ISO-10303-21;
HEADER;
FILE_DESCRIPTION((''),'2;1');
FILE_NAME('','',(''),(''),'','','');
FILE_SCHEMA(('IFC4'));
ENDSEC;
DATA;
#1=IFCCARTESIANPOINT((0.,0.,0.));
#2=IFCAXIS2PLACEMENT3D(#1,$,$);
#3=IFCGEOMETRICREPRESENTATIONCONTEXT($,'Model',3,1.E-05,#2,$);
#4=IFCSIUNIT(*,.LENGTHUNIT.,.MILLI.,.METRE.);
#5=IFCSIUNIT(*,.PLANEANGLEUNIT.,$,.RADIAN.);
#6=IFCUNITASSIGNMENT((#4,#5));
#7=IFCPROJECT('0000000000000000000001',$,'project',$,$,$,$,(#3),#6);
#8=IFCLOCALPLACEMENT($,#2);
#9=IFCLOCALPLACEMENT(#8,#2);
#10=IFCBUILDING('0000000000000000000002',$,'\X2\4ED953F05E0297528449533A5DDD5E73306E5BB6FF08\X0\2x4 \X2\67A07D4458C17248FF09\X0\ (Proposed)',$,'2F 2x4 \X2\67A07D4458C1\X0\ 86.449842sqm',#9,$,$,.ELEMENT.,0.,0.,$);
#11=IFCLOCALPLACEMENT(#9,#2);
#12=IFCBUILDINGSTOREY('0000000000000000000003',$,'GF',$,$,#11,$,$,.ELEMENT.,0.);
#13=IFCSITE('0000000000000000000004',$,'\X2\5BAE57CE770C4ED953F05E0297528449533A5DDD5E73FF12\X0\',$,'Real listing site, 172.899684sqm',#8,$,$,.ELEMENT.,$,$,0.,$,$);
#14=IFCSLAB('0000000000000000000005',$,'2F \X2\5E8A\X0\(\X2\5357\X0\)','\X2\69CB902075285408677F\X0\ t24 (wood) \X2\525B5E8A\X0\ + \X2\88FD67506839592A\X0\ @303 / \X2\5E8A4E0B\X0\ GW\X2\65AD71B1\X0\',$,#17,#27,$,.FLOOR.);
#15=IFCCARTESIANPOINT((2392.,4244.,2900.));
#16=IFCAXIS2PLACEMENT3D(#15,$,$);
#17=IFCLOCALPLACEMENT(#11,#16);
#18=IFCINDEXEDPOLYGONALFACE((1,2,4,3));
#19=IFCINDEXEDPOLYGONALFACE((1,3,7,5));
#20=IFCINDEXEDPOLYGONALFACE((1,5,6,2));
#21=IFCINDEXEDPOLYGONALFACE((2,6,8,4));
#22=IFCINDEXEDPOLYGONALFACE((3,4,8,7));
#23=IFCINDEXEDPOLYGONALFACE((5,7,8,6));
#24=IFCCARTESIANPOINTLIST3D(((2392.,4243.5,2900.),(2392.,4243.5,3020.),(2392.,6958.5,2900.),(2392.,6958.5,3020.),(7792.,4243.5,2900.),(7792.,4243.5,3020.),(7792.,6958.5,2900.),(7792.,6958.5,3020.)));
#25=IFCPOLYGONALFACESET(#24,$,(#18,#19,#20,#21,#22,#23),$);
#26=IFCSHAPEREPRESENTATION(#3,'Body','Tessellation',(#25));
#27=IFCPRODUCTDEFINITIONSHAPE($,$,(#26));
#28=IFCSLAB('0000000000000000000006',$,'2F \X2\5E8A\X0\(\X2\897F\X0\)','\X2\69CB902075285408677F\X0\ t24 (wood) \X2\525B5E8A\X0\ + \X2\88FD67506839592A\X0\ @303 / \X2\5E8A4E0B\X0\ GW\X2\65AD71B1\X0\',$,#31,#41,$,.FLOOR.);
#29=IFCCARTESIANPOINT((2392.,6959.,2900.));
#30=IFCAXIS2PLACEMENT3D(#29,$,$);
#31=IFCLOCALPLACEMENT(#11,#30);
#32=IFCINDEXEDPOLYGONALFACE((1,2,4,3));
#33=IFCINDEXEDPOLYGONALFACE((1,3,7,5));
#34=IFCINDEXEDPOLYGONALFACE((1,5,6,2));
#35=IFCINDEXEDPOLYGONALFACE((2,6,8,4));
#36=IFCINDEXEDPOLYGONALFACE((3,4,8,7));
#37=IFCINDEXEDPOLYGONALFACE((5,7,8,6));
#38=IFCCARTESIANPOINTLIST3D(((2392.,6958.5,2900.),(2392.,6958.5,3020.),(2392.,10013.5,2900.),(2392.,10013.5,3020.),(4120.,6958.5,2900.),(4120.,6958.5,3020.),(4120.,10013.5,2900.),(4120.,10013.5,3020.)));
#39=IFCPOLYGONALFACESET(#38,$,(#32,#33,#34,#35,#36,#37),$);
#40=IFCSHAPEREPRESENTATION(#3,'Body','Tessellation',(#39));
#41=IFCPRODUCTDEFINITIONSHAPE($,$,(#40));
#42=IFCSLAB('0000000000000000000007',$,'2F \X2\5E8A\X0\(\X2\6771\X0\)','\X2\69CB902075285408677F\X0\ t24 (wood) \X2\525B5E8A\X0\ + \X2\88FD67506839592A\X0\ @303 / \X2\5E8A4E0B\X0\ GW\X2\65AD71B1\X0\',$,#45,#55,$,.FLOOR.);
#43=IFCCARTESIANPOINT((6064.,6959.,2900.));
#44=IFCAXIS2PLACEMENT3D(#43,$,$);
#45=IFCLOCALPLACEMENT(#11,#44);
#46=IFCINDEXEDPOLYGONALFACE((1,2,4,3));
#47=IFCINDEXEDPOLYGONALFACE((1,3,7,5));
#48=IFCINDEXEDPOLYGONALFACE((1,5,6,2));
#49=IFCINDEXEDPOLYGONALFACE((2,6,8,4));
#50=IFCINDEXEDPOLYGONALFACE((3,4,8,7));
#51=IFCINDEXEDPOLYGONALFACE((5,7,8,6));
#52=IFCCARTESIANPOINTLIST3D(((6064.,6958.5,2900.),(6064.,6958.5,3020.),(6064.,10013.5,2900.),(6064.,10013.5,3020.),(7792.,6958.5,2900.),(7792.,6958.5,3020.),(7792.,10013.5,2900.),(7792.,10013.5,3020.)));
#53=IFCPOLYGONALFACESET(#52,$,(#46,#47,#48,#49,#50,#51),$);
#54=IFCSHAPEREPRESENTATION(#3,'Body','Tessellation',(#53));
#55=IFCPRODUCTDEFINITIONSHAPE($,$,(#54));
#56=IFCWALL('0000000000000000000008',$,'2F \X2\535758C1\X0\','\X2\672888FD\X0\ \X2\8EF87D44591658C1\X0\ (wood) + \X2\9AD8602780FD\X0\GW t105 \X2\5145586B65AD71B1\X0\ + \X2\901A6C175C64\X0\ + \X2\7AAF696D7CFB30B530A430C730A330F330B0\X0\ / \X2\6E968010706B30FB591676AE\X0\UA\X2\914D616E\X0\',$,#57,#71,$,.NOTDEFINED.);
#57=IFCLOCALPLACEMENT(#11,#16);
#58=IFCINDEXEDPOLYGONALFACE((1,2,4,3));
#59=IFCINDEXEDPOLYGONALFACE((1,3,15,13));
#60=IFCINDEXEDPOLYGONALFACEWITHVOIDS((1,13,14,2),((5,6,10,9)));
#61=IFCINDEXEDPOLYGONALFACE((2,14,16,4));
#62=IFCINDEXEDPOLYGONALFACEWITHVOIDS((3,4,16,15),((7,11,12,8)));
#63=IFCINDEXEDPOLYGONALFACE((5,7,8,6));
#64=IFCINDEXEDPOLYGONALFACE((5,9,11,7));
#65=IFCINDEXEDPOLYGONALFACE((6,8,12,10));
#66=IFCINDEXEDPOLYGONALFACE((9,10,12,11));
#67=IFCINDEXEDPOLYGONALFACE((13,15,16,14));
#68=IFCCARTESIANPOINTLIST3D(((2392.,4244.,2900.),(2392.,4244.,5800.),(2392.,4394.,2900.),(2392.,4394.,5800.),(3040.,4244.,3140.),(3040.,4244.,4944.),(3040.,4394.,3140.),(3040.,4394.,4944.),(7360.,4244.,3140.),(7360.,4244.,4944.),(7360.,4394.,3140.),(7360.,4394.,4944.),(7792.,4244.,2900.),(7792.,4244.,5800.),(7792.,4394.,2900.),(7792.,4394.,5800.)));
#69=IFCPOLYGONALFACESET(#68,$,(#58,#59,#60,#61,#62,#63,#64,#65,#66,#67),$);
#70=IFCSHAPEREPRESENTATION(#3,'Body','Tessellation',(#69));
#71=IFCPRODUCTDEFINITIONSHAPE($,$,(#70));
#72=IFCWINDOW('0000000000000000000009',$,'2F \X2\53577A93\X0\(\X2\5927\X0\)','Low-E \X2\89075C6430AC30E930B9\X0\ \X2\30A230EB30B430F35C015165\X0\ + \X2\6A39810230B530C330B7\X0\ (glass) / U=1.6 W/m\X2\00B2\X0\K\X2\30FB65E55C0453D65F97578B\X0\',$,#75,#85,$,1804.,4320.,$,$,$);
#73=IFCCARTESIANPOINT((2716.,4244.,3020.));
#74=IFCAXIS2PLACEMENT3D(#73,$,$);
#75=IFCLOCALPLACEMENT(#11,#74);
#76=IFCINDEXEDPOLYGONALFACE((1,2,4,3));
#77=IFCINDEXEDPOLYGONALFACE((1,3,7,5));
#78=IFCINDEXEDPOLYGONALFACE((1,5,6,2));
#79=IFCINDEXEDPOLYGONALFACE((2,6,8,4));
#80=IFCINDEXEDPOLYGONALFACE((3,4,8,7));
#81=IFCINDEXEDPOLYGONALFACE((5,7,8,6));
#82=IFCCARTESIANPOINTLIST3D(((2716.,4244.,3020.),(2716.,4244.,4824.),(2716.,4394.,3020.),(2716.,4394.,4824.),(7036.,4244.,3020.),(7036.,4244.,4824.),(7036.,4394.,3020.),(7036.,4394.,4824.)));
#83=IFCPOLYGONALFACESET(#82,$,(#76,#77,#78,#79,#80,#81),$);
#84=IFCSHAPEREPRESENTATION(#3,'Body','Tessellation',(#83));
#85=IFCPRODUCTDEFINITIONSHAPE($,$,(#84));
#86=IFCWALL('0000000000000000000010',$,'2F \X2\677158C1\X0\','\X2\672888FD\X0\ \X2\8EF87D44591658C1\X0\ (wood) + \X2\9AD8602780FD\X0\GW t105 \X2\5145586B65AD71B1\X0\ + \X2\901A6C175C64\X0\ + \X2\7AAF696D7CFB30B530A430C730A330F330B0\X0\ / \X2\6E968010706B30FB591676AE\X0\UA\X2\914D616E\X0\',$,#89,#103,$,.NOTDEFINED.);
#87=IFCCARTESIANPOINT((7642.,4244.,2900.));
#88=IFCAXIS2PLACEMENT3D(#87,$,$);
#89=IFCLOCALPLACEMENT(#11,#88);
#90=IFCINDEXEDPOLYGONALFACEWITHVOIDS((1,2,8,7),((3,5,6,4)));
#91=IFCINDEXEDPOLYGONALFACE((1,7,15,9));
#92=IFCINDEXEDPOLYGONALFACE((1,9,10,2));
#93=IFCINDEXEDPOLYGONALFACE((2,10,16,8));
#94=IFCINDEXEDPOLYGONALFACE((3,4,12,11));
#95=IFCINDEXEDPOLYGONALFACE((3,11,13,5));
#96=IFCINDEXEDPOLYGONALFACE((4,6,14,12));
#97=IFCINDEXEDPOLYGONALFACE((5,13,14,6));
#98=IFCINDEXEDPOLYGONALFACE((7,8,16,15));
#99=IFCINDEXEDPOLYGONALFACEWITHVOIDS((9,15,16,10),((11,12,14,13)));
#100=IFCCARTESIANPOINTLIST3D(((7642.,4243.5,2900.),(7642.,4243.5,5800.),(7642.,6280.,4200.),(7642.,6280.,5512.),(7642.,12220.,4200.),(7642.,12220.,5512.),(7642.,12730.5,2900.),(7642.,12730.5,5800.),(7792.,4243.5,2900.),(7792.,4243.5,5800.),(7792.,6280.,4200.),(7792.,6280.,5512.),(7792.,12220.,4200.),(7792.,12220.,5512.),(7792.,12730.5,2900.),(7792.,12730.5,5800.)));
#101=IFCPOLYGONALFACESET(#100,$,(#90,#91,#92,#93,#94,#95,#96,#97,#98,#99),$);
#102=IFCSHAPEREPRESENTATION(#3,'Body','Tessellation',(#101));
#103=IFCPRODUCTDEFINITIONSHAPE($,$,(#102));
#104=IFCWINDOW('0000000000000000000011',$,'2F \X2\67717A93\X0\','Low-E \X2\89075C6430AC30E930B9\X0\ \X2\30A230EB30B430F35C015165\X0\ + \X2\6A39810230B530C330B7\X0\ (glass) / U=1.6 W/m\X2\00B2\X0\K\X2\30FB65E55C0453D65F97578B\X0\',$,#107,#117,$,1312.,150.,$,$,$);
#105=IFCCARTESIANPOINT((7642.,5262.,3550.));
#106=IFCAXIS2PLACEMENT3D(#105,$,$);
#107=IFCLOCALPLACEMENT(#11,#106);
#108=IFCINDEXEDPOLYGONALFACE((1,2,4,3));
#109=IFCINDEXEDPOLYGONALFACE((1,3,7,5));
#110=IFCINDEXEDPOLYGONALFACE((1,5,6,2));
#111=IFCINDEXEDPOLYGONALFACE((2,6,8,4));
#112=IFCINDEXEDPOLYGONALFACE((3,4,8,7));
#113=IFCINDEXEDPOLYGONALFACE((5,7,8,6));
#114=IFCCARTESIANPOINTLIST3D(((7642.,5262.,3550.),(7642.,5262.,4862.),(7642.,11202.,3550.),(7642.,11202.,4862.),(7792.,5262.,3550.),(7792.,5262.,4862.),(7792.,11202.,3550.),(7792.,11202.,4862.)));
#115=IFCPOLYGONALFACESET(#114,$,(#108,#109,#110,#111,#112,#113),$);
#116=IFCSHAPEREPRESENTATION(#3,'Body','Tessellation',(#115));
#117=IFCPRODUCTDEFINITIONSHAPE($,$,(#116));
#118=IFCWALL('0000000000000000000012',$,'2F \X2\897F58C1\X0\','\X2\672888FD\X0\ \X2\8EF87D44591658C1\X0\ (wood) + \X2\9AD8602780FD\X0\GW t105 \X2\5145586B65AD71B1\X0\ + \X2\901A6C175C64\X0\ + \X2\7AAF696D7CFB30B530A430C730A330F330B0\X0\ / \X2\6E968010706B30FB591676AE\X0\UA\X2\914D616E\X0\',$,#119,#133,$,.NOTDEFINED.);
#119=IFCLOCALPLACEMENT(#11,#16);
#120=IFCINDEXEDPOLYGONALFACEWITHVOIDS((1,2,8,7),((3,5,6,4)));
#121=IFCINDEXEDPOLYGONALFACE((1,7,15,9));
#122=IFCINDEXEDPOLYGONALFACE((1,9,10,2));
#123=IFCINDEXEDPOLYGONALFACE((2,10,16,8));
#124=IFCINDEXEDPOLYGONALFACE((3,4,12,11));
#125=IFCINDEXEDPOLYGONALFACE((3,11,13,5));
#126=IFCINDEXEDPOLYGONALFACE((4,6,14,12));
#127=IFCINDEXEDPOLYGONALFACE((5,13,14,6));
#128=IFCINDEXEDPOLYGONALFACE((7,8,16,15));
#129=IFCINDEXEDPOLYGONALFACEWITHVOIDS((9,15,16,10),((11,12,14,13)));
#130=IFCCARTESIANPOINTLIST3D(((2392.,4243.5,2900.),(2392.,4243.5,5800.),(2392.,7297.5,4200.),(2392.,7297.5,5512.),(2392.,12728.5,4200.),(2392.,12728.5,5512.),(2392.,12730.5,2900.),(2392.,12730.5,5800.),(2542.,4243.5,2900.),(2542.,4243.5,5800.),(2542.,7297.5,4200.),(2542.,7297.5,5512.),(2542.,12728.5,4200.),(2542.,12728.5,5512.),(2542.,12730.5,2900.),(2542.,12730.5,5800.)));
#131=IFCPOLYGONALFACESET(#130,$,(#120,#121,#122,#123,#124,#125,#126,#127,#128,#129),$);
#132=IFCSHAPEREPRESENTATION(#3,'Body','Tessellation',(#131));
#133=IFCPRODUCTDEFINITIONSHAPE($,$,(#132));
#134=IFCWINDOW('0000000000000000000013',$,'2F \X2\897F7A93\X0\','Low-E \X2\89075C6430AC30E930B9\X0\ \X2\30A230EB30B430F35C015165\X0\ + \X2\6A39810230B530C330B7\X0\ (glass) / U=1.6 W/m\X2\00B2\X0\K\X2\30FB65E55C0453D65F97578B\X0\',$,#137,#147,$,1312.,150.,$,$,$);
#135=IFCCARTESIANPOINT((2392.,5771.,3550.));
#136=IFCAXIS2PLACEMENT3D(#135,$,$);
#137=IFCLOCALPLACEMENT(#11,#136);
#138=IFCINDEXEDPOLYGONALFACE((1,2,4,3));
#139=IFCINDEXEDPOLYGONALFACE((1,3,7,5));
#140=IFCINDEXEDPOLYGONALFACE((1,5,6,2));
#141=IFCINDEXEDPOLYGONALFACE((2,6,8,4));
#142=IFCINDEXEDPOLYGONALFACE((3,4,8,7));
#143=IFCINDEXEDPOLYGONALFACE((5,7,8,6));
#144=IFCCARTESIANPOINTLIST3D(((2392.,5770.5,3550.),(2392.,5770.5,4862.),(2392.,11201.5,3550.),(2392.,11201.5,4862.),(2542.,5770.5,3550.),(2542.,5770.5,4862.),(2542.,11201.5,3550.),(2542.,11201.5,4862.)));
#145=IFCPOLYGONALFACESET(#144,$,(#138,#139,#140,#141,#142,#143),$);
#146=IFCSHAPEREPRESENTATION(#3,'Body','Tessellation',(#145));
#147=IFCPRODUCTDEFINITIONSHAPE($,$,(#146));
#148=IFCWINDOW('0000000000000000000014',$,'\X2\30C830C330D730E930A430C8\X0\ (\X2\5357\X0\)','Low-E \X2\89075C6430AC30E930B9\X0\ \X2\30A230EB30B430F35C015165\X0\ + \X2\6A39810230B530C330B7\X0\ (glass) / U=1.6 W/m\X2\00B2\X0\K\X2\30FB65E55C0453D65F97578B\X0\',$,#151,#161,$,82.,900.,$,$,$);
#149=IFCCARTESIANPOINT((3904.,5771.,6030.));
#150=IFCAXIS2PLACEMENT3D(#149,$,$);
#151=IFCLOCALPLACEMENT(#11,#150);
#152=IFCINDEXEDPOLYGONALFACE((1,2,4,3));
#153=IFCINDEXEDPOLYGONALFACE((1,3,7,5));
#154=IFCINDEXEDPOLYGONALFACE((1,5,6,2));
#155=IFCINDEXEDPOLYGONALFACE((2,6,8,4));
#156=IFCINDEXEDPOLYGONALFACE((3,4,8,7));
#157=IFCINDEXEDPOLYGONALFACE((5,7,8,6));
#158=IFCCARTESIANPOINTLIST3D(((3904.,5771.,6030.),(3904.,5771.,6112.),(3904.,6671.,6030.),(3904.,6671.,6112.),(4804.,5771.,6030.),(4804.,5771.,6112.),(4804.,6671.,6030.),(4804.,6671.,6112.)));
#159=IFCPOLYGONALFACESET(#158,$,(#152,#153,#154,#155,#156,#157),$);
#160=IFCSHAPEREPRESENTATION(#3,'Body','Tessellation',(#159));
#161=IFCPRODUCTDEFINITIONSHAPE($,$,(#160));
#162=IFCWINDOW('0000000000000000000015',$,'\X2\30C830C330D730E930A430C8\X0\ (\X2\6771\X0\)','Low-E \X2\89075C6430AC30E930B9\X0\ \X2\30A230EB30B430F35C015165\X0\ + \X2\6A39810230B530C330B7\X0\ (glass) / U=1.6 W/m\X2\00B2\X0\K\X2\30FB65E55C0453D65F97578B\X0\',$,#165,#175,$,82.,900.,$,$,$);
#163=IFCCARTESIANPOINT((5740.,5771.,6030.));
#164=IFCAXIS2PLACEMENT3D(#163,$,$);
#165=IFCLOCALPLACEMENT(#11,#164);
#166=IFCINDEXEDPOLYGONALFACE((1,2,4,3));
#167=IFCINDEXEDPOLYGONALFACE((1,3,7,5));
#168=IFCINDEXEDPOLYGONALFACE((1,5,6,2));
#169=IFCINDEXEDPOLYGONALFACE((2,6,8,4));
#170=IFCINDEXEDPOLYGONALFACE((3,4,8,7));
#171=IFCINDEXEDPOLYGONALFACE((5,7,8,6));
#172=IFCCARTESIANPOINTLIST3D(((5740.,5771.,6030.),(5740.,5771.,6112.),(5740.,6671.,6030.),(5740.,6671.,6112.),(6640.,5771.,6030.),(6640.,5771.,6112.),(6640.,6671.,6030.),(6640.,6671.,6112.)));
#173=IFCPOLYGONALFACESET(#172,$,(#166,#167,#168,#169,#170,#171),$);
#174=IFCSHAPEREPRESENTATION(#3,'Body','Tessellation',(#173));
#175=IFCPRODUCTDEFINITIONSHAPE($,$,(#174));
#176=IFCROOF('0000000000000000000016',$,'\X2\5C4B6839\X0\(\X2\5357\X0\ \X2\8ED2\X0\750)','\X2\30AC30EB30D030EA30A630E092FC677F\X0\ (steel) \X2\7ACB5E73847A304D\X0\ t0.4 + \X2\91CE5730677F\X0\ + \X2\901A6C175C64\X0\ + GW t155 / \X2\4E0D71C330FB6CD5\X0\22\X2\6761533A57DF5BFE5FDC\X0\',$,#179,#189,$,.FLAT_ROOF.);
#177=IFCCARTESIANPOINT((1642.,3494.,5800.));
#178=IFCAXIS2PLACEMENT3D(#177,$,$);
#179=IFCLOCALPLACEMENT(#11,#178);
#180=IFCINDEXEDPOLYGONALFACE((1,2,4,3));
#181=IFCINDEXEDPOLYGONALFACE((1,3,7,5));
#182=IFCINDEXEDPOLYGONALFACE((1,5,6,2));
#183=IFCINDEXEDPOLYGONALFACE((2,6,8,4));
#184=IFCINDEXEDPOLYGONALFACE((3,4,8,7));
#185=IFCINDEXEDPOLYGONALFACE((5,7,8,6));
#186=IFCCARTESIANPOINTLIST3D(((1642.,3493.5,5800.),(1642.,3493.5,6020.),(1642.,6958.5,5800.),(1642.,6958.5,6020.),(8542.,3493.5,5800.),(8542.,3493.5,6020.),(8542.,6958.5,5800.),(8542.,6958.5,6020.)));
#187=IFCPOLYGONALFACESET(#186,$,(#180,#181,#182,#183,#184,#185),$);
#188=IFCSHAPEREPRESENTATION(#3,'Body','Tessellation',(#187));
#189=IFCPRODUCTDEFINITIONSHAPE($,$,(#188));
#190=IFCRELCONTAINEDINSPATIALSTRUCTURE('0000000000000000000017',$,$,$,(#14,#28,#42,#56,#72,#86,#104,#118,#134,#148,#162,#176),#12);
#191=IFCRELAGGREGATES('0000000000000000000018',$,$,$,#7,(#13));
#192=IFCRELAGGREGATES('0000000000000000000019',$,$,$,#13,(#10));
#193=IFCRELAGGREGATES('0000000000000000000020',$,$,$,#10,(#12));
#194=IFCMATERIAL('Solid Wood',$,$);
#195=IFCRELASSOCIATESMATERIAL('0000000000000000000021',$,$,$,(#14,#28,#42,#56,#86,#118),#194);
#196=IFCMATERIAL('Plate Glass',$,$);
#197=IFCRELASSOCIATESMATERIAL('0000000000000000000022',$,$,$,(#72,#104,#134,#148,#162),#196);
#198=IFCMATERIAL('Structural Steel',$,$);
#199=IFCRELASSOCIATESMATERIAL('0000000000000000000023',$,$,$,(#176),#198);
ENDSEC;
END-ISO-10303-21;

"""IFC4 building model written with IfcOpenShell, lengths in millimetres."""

from ifc_helpers import new_model, si_unit, frame, frame_2d, origin, place, context, project, spatial, rectangle, extrude, material, element, fill, save


model = new_model("IFC4")

# Units and contexts
model_context = context("Model", 3, precision=1e-05, world=origin())
ifc_project = project(units=[si_unit("LENGTHUNIT", "METRE", prefix="MILLI"), si_unit("PLANEANGLEUNIT", "RADIAN")], contexts=[model_context])

# Site, building, storey
site_placement = place(None, origin())
site = spatial("IfcSite", under=ifc_project, at=site_placement, Name="宮城県仙台市青葉区川平２", ObjectType="Real listing site, 172.899684sqm", CompositionType="ELEMENT", RefElevation=0.0)
building_placement = place(site_placement, origin())
building = spatial("IfcBuilding", under=site, at=building_placement, Name="仙台市青葉区川平の家（2x4 枠組壁版） (Proposed)", ObjectType="2F 2x4 枠組壁 86.449842sqm", CompositionType="ELEMENT", ElevationOfRefHeight=0.0, ElevationOfTerrain=0.0)
storey_placement = place(building_placement, origin())
storey = spatial("IfcBuildingStorey", under=building, at=storey_placement, Name="GF", CompositionType="ELEMENT", Elevation=0.0)

# Slabs
ifc_material_1 = material(Name="Solid Wood")
slab_1_placement = place(storey_placement, frame((2392.0, 4244.0, 2900.0)))
element("IfcSlab", 1, at=slab_1_placement, inside=storey, material=ifc_material_1, Name="2F 床(南)", Description="構造用合板 t24 (wood) 剛床 + 製材根太 @303 / 床下 GW断熱", PredefinedType="FLOOR", context=model_context, shape_type="SweptSolid", body=[
    extrude(rectangle(XDim=5400.0, YDim=2715.0, at=frame_2d((2700.0, 1357.0))), frame((2392.0, 4244.0, 2900.0)), (0.0, 0.0, 1.0), 120.0),
])
slab_2_placement = place(storey_placement, frame((2392.0, 6959.0, 2900.0)))
element("IfcSlab", 2, at=slab_2_placement, inside=storey, material=ifc_material_1, Name="2F 床(西)", Description="構造用合板 t24 (wood) 剛床 + 製材根太 @303 / 床下 GW断熱", PredefinedType="FLOOR", context=model_context, shape_type="SweptSolid", body=[
    extrude(rectangle(XDim=1728.0, YDim=3055.0, at=frame_2d((864.0, 1527.0))), frame((2392.0, 6959.0, 2900.0)), (0.0, 0.0, 1.0), 120.0),
])
slab_3_placement = place(storey_placement, frame((6064.0, 6959.0, 2900.0)))
element("IfcSlab", 3, at=slab_3_placement, inside=storey, material=ifc_material_1, Name="2F 床(東)", Description="構造用合板 t24 (wood) 剛床 + 製材根太 @303 / 床下 GW断熱", PredefinedType="FLOOR", context=model_context, shape_type="SweptSolid", body=[
    extrude(rectangle(XDim=1728.0, YDim=3055.0, at=frame_2d((864.0, 1527.0))), frame((6064.0, 6959.0, 2900.0)), (0.0, 0.0, 1.0), 120.0),
])

# Walls, openings, windows
wall_1_placement = place(storey_placement, frame((2392.0, 4244.0, 2900.0)))
wall_1 = element("IfcWall", 4, at=wall_1_placement, inside=storey, material=ifc_material_1, Name="2F 南壁", Description="木製 軸組外壁 (wood) + 高性能GW t105 充填断熱 + 通気層 + 窯業系サイディング / 準耐火・外皮UA配慮", PredefinedType="NOTDEFINED", context=model_context, shape_type="SweptSolid", body=[
    extrude(rectangle(XDim=5400.0, YDim=150.0, at=frame_2d((2700.0, 75.0))), frame((2392.0, 4244.0, 2900.0)), (0.0, 0.0, 1.0), 2900.0),
])
opening_1_placement = place(storey_placement, frame((2716.0, 4244.0, 3020.0)))
opening_1 = element("IfcOpeningElement", 5, at=opening_1_placement, cuts=wall_1, PredefinedType="NOTDEFINED", context=model_context, shape_type="SweptSolid", body=[
    extrude(rectangle(XDim=4320.0, YDim=150.0, at=frame_2d((2160.0, 75.0))), frame((2716.0, 4244.0, 3020.0)), (0.0, 0.0, 1.0), 1804.0),
])
ifc_material_2 = material(Name="Plate Glass")
window_1_placement = place(storey_placement, frame((2716.0, 4244.0, 3020.0)))
window_1 = element("IfcWindow", 6, at=window_1_placement, inside=storey, material=ifc_material_2, Name="2F 南窓(大)", Description="Low-E 複層ガラス アルゴン封入 + 樹脂サッシ (glass) / U=1.6 W/m²K・日射取得型", OverallHeight=1804.0, OverallWidth=4320.0, context=model_context, shape_type="SweptSolid", body=[
    extrude(rectangle(XDim=4320.0, YDim=150.0, at=frame_2d((2160.0, 75.0))), frame((2716.0, 4244.0, 3020.0)), (0.0, 0.0, 1.0), 1804.0),
])
fill(opening_1, window_1)
wall_2_placement = place(storey_placement, frame((7642.0, 4244.0, 2900.0)))
wall_2 = element("IfcWall", 7, at=wall_2_placement, inside=storey, material=ifc_material_1, Name="2F 東壁", Description="木製 軸組外壁 (wood) + 高性能GW t105 充填断熱 + 通気層 + 窯業系サイディング / 準耐火・外皮UA配慮", PredefinedType="NOTDEFINED", context=model_context, shape_type="SweptSolid", body=[
    extrude(rectangle(XDim=150.0, YDim=8487.0, at=frame_2d((75.0, 4243.0))), frame((7642.0, 4244.0, 2900.0)), (0.0, 0.0, 1.0), 2900.0),
])
opening_2_placement = place(storey_placement, frame((7642.0, 5262.0, 3550.0)))
opening_2 = element("IfcOpeningElement", 8, at=opening_2_placement, cuts=wall_2, PredefinedType="NOTDEFINED", context=model_context, shape_type="SweptSolid", body=[
    extrude(rectangle(XDim=150.0, YDim=5940.0, at=frame_2d((75.0, 2970.0))), frame((7642.0, 5262.0, 3550.0)), (0.0, 0.0, 1.0), 1312.0),
])
window_2_placement = place(storey_placement, frame((7642.0, 5262.0, 3550.0)))
window_2 = element("IfcWindow", 9, at=window_2_placement, inside=storey, material=ifc_material_2, Name="2F 東窓", Description="Low-E 複層ガラス アルゴン封入 + 樹脂サッシ (glass) / U=1.6 W/m²K・日射取得型", OverallHeight=1312.0, OverallWidth=150.0, context=model_context, shape_type="SweptSolid", body=[
    extrude(rectangle(XDim=150.0, YDim=5940.0, at=frame_2d((75.0, 2970.0))), frame((7642.0, 5262.0, 3550.0)), (0.0, 0.0, 1.0), 1312.0),
])
fill(opening_2, window_2)
wall_3_placement = place(storey_placement, frame((2392.0, 4244.0, 2900.0)))
wall_3 = element("IfcWall", 10, at=wall_3_placement, inside=storey, material=ifc_material_1, Name="2F 西壁", Description="木製 軸組外壁 (wood) + 高性能GW t105 充填断熱 + 通気層 + 窯業系サイディング / 準耐火・外皮UA配慮", PredefinedType="NOTDEFINED", context=model_context, shape_type="SweptSolid", body=[
    extrude(rectangle(XDim=150.0, YDim=8487.0, at=frame_2d((75.0, 4243.0))), frame((2392.0, 4244.0, 2900.0)), (0.0, 0.0, 1.0), 2900.0),
])
opening_3_placement = place(storey_placement, frame((2392.0, 5771.0, 3550.0)))
opening_3 = element("IfcOpeningElement", 11, at=opening_3_placement, cuts=wall_3, PredefinedType="NOTDEFINED", context=model_context, shape_type="SweptSolid", body=[
    extrude(rectangle(XDim=150.0, YDim=5431.0, at=frame_2d((75.0, 2715.0))), frame((2392.0, 5771.0, 3550.0)), (0.0, 0.0, 1.0), 1312.0),
])
window_3_placement = place(storey_placement, frame((2392.0, 5771.0, 3550.0)))
window_3 = element("IfcWindow", 12, at=window_3_placement, inside=storey, material=ifc_material_2, Name="2F 西窓", Description="Low-E 複層ガラス アルゴン封入 + 樹脂サッシ (glass) / U=1.6 W/m²K・日射取得型", OverallHeight=1312.0, OverallWidth=150.0, context=model_context, shape_type="SweptSolid", body=[
    extrude(rectangle(XDim=150.0, YDim=5431.0, at=frame_2d((75.0, 2715.0))), frame((2392.0, 5771.0, 3550.0)), (0.0, 0.0, 1.0), 1312.0),
])
fill(opening_3, window_3)

# Windows
window_4_placement = place(storey_placement, frame((3904.0, 5771.0, 6030.0)))
element("IfcWindow", 13, at=window_4_placement, inside=storey, material=ifc_material_2, Name="トップライト (南)", Description="Low-E 複層ガラス アルゴン封入 + 樹脂サッシ (glass) / U=1.6 W/m²K・日射取得型", OverallHeight=82.0, OverallWidth=900.0, context=model_context, shape_type="SweptSolid", body=[
    extrude(rectangle(XDim=900.0, YDim=900.0, at=frame_2d((450.0, 450.0))), frame((3904.0, 5771.0, 6030.0)), (0.0, 0.0, 1.0), 82.0),
])
window_5_placement = place(storey_placement, frame((5740.0, 5771.0, 6030.0)))
element("IfcWindow", 14, at=window_5_placement, inside=storey, material=ifc_material_2, Name="トップライト (東)", Description="Low-E 複層ガラス アルゴン封入 + 樹脂サッシ (glass) / U=1.6 W/m²K・日射取得型", OverallHeight=82.0, OverallWidth=900.0, context=model_context, shape_type="SweptSolid", body=[
    extrude(rectangle(XDim=900.0, YDim=900.0, at=frame_2d((450.0, 450.0))), frame((5740.0, 5771.0, 6030.0)), (0.0, 0.0, 1.0), 82.0),
])

# Roof
ifc_material_3 = material(Name="Structural Steel")
roof_1_placement = place(storey_placement, frame((1642.0, 3494.0, 5800.0)))
element("IfcRoof", 15, at=roof_1_placement, inside=storey, material=ifc_material_3, Name="屋根(南 軒750)", Description="ガルバリウム鋼板 (steel) 立平葺き t0.4 + 野地板 + 通気層 + GW t155 / 不燃・法22条区域対応", PredefinedType="FLAT_ROOF", context=model_context, shape_type="SweptSolid", body=[
    extrude(rectangle(XDim=6900.0, YDim=3465.0, at=frame_2d((3450.0, 1732.0))), frame((1642.0, 3494.0, 5800.0)), (0.0, 0.0, 1.0), 220.0),
])

save(model, "model.ifc")
